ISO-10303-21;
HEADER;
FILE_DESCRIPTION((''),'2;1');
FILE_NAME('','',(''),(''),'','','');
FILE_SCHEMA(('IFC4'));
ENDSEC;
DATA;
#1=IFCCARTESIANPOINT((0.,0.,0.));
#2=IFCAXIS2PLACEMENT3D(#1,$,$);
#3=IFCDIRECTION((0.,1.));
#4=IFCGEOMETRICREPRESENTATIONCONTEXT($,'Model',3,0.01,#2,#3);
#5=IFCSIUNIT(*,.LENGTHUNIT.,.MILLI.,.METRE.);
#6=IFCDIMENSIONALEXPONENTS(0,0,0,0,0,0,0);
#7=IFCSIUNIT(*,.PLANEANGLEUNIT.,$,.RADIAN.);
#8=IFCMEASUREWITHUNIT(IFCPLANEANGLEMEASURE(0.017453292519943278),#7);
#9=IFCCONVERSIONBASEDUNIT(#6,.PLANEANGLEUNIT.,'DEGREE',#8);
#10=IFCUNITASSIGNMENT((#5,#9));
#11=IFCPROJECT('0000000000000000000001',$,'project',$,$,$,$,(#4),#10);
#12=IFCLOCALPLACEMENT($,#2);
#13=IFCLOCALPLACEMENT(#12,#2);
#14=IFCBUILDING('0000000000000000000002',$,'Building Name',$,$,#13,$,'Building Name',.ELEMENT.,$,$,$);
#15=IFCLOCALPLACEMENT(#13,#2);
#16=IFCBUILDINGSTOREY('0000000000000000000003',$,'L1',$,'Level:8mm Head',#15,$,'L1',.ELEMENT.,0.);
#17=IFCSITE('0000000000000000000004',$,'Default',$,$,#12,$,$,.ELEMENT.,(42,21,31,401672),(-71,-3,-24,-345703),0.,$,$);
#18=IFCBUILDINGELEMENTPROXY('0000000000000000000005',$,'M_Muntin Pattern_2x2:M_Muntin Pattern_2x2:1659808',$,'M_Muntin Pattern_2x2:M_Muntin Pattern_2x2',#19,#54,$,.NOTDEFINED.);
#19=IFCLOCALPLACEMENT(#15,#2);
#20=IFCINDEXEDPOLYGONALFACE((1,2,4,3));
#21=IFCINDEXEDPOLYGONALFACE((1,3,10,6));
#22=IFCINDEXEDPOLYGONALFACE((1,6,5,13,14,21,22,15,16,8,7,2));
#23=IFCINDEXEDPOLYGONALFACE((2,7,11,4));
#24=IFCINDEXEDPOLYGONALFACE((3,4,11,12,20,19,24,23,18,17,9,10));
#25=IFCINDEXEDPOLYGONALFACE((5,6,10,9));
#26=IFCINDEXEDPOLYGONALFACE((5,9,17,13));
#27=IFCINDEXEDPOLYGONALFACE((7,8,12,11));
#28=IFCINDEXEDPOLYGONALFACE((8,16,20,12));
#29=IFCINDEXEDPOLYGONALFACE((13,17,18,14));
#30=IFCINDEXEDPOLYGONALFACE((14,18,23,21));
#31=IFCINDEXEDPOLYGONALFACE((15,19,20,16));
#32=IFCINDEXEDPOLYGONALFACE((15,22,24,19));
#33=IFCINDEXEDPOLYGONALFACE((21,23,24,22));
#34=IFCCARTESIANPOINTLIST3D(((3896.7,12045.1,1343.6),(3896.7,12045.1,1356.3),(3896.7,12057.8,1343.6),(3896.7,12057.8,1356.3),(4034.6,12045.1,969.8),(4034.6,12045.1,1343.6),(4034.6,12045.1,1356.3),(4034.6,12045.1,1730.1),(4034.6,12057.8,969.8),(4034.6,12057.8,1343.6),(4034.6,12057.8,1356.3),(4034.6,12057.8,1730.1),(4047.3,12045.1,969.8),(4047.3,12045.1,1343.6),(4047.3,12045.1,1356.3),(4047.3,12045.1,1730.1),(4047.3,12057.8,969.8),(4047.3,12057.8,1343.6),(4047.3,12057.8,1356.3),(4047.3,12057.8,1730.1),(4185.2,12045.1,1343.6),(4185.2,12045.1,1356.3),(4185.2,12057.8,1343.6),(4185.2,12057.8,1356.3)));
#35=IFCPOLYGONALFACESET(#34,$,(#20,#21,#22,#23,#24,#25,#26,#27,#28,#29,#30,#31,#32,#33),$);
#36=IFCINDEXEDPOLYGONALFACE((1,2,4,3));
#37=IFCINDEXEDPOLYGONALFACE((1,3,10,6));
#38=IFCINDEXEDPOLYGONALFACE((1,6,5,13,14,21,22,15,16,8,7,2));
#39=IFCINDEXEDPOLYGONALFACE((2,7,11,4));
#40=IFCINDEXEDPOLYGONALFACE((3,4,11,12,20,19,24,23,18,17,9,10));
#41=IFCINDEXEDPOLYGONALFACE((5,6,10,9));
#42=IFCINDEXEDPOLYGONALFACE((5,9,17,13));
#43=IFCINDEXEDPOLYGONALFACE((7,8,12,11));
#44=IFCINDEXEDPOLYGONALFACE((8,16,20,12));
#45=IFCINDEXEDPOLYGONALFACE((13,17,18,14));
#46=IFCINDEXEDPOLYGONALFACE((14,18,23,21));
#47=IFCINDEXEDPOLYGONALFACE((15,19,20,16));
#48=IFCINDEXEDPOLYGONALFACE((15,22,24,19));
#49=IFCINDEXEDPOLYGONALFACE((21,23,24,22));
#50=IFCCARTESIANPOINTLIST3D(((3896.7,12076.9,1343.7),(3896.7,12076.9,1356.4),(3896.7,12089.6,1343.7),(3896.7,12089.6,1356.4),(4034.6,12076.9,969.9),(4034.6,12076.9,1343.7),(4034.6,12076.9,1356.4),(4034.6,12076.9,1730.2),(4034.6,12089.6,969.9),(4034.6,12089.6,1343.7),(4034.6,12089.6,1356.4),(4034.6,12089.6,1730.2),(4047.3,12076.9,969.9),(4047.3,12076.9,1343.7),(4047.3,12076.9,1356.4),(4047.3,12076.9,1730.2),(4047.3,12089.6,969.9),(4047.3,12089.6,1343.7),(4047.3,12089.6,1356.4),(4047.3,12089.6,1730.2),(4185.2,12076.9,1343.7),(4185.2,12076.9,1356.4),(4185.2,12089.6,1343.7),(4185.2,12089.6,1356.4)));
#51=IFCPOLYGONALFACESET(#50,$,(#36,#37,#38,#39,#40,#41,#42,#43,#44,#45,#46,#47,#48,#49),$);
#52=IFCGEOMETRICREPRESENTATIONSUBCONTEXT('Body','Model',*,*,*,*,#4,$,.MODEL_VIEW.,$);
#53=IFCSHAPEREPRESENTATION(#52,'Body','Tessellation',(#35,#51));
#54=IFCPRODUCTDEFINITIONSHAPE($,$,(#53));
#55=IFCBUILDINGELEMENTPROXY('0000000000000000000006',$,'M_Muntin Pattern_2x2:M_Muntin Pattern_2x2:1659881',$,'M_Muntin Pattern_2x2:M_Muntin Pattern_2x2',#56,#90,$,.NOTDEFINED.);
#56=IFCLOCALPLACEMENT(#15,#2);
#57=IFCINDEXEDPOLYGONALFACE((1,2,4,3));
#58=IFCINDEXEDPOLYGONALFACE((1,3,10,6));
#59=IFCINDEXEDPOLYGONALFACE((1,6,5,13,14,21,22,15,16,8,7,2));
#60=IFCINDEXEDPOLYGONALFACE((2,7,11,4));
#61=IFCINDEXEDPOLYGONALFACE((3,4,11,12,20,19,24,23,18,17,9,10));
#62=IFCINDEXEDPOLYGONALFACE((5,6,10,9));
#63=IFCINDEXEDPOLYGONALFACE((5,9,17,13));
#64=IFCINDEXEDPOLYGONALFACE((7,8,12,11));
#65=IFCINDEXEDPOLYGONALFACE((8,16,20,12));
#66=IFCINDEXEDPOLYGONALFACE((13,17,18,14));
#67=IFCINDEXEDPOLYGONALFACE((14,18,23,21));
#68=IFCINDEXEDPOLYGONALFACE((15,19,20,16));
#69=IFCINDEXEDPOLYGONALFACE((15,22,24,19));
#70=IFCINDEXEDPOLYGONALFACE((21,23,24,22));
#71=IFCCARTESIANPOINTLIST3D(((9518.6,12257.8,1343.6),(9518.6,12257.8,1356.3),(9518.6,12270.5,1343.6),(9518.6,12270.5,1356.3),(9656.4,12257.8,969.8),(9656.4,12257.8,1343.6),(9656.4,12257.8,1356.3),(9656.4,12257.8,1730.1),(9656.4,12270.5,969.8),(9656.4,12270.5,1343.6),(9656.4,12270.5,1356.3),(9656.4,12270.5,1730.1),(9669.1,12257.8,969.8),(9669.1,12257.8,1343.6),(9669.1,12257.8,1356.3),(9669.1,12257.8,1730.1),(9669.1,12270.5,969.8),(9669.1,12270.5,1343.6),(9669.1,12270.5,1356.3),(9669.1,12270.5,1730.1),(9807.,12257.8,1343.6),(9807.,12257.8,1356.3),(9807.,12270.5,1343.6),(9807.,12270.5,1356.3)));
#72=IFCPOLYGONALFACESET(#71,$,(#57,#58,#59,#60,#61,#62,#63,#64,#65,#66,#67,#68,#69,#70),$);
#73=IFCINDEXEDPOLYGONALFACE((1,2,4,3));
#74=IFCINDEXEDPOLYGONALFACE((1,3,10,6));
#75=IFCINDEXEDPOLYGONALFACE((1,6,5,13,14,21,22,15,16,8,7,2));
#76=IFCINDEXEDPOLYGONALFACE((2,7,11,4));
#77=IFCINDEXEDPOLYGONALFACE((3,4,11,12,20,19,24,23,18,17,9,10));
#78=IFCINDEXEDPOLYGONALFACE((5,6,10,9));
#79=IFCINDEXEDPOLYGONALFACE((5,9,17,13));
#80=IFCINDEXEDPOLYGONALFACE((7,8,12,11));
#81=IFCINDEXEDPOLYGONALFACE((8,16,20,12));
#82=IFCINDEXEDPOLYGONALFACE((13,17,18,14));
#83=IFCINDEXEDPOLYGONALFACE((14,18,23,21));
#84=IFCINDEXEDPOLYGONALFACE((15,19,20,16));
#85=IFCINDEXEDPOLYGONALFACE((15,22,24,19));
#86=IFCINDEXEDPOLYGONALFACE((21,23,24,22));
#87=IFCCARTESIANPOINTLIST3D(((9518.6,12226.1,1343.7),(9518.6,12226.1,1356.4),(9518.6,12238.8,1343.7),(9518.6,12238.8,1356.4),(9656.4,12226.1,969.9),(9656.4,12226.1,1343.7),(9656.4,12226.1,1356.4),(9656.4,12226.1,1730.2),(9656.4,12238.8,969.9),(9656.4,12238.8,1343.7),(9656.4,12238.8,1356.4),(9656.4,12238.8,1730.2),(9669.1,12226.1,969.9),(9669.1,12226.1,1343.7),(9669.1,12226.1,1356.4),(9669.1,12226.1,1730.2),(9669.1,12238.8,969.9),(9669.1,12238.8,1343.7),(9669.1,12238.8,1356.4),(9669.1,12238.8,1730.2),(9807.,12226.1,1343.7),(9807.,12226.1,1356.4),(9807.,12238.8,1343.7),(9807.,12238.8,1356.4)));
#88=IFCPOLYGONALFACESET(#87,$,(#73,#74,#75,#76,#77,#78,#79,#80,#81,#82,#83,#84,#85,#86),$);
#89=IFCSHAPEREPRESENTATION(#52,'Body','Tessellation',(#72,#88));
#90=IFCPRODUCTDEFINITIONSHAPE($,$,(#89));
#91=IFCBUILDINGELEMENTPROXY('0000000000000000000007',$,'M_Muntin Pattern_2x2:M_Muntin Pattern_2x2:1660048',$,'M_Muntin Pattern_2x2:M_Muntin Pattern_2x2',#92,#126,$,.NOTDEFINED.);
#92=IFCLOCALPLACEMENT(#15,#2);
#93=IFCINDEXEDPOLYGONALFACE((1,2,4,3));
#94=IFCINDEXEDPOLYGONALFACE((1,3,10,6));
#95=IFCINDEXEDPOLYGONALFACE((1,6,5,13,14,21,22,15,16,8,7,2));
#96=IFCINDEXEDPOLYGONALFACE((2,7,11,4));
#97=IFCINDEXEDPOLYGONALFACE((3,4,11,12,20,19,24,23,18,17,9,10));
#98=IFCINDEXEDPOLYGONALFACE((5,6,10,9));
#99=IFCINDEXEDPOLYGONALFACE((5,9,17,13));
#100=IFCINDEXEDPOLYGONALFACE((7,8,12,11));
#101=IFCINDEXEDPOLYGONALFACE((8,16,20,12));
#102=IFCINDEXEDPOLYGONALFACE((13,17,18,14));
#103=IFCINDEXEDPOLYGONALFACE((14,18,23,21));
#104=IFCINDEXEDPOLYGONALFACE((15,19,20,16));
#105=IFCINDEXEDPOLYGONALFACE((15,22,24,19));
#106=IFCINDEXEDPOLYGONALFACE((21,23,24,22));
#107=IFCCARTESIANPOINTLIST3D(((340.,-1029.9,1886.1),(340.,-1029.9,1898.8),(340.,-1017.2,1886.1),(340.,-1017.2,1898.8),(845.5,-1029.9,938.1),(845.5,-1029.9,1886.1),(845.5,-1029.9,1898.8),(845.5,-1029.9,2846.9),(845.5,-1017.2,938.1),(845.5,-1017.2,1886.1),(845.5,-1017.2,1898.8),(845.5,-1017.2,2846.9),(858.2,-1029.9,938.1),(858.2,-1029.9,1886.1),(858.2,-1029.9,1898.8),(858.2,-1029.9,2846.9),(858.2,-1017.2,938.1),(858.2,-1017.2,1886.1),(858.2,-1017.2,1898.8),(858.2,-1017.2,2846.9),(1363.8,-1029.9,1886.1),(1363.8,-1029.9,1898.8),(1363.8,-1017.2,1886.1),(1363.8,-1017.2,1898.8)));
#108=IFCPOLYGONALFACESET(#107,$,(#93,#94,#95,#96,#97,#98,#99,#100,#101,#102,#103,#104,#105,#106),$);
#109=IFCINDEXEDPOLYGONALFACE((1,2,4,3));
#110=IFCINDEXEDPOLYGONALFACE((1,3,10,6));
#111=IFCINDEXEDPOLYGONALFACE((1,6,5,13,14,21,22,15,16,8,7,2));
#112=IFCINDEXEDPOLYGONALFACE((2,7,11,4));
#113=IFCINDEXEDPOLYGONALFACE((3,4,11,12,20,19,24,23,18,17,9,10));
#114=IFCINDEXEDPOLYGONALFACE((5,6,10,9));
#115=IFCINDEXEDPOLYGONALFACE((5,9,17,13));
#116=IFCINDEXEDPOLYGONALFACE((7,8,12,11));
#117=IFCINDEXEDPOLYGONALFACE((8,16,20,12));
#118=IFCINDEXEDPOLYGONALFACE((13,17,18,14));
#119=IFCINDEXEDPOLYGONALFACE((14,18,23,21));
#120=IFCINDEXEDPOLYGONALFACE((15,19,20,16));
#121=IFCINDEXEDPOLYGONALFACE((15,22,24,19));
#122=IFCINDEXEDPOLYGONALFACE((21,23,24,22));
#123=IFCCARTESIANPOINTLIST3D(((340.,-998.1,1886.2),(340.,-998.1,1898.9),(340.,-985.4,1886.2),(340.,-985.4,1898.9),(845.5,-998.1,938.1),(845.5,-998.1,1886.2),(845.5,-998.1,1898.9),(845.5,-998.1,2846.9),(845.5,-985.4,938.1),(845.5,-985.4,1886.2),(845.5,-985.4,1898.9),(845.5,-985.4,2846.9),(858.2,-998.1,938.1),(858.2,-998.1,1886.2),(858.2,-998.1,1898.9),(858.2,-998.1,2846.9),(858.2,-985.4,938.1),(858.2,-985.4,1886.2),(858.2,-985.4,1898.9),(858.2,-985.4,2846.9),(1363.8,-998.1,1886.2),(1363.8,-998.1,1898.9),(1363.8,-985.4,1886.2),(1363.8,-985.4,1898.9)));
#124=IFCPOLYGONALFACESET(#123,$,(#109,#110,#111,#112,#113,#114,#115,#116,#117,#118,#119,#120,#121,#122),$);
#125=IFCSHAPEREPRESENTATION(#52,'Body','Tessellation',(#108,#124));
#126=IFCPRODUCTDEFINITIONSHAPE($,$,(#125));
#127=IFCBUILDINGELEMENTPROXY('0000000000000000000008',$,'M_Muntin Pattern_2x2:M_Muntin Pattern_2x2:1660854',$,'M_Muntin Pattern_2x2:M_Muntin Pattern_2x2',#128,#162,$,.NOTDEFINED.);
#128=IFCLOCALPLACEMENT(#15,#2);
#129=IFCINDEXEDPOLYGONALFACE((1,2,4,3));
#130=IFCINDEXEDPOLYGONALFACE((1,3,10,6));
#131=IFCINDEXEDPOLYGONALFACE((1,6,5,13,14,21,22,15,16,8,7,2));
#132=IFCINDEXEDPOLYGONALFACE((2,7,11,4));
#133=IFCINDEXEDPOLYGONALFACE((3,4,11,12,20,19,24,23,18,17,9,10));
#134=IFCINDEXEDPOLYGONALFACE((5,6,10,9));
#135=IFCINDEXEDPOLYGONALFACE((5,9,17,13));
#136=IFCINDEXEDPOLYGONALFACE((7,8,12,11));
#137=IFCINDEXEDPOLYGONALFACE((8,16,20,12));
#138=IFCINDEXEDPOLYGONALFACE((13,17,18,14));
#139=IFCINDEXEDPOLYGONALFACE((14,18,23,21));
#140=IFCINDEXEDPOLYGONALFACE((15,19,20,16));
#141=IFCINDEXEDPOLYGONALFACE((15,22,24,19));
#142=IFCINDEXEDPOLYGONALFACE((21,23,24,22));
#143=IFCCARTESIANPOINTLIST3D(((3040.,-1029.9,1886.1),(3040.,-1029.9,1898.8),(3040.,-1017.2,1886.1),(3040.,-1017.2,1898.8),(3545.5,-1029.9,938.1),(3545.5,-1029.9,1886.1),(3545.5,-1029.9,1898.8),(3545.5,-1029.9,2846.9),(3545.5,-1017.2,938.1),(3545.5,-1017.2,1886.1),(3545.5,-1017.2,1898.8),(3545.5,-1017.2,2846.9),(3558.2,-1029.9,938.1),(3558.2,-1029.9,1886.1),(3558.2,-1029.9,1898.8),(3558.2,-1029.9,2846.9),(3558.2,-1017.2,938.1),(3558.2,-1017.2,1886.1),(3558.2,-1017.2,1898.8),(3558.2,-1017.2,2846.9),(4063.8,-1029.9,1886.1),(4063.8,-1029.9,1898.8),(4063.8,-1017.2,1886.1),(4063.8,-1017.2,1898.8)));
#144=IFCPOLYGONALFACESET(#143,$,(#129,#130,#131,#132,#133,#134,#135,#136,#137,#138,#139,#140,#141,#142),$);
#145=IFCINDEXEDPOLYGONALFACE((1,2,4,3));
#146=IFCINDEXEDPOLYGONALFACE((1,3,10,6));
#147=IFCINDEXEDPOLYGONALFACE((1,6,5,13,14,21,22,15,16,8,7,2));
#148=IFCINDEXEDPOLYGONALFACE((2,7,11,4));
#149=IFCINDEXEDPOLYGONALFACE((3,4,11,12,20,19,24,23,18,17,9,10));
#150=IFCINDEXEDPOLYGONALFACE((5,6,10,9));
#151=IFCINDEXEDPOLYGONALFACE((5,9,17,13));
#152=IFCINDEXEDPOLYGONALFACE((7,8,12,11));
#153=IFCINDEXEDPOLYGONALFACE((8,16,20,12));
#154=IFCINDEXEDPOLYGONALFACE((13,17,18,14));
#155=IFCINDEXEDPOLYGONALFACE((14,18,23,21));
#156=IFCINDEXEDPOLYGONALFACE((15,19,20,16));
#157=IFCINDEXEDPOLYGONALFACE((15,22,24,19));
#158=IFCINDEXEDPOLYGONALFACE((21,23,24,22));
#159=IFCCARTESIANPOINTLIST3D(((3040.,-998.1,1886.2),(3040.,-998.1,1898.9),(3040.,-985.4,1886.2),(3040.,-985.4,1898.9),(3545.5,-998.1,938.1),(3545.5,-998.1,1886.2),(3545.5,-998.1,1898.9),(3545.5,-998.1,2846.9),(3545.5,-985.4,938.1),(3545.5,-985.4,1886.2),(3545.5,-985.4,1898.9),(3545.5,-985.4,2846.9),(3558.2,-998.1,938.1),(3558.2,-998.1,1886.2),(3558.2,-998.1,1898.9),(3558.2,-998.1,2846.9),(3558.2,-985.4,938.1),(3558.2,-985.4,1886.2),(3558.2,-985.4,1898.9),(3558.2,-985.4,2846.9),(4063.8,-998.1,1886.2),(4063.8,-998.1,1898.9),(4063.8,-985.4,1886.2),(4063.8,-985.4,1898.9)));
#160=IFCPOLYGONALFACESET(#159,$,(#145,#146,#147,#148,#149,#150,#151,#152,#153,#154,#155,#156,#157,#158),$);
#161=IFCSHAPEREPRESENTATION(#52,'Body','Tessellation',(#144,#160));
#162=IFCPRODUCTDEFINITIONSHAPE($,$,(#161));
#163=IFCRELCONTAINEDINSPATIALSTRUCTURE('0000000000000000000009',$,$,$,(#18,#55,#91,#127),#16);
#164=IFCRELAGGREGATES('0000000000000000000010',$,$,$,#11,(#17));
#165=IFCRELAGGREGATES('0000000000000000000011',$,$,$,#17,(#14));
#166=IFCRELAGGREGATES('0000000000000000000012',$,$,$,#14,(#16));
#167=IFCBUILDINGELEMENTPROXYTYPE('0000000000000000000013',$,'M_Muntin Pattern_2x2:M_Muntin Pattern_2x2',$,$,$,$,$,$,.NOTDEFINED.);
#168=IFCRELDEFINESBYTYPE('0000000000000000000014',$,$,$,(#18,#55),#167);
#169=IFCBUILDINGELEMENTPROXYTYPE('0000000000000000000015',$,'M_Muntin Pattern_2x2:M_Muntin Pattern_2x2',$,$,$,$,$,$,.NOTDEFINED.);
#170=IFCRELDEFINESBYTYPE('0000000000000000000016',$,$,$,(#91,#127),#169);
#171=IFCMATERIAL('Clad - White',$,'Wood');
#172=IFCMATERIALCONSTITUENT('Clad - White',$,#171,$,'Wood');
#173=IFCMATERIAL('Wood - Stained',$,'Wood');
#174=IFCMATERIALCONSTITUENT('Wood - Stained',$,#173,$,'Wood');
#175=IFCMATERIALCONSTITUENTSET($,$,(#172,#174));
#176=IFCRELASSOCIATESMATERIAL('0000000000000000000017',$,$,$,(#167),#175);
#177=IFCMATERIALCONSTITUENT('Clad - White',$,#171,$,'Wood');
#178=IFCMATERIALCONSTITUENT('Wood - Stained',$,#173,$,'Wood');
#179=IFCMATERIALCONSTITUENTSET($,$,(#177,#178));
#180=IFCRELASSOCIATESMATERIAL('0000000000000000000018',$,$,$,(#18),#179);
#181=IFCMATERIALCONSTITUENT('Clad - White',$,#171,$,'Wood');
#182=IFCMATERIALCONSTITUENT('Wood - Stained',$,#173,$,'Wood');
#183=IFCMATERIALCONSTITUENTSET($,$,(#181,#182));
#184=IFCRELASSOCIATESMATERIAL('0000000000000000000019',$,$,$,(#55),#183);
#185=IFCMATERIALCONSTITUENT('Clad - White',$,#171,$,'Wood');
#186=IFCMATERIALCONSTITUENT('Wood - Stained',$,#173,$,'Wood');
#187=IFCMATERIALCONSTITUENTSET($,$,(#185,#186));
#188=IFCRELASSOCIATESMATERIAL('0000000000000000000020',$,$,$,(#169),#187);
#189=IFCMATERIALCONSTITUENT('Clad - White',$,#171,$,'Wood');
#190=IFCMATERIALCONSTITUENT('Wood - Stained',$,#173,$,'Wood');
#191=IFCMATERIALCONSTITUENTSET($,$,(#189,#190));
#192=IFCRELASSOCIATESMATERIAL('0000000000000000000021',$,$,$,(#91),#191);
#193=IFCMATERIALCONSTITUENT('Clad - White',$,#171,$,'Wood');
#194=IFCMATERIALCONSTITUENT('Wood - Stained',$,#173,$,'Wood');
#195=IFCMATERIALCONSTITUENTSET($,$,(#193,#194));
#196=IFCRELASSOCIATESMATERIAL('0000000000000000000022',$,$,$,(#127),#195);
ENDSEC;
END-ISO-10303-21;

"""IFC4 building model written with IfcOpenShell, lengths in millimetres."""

from ifc_helpers import new_model, entity, si_unit, converted_unit, direction, frame, origin, place, context, subcontext, project, spatial, indexed_curve, outline, extrude, source, transform, mapped, material, constituent, constituent_set, type_object, type_shapes, element, save


model = new_model("IFC4")

# Units and contexts
model_context = context("Model", 3, precision=0.01, world=origin(), true_north=direction((0.0, 1.0)))
body_context = subcontext(model_context, "Body", "Model", "MODEL_VIEW")
ifc_project = project(units=[si_unit("LENGTHUNIT", "METRE", prefix="MILLI"), converted_unit("PLANEANGLEUNIT", "DEGREE", entity("IfcPlaneAngleMeasure", 0.017453292519943278), si_unit("PLANEANGLEUNIT", "RADIAN"), dimensions=[0, 0, 0, 0, 0, 0, 0])], contexts=[model_context])

# Site, building, storey
site_placement = place(None, origin())
site = spatial("IfcSite", under=ifc_project, at=site_placement, Name="Default", CompositionType="ELEMENT", RefLatitude=(42, 21, 31, 401672), RefLongitude=(-71, -3, -24, -345703), RefElevation=0.0)
building_placement = place(site_placement, origin())
building = spatial("IfcBuilding", under=site, at=building_placement, Name="Building Name", LongName="Building Name", CompositionType="ELEMENT")
storey_placement = place(building_placement, origin())
storey = spatial("IfcBuildingStorey", under=building, at=storey_placement, Name="L1", ObjectType="Level:8mm Head", LongName="L1", CompositionType="ELEMENT", Elevation=0.0)

# Building element proxies
ifc_material_1 = material(Name="Clad - White", Category="Wood")
ifc_material_2 = material(Name="Wood - Stained", Category="Wood")
ifc_constituent_1 = constituent(ifc_material_1, Name="Clad - White", Category="Wood")
ifc_constituent_2 = constituent(ifc_material_2, Name="Wood - Stained", Category="Wood")
ifc_constituent_set_1 = constituent_set(constituents=[ifc_constituent_1, ifc_constituent_2])
ifc_constituent_3 = constituent(ifc_material_1, Name="Clad - White", Category="Wood")
ifc_constituent_4 = constituent(ifc_material_2, Name="Wood - Stained", Category="Wood")
ifc_constituent_set_2 = constituent_set(constituents=[ifc_constituent_3, ifc_constituent_4])
building_element_proxy_type_1 = type_object("IfcBuildingElementProxyType", Name="M_Muntin Pattern_2x2:M_Muntin Pattern_2x2", PredefinedType="NOTDEFINED", material=ifc_constituent_set_2)
shared_shape_1 = source(origin(), body_context, "Body", "SweptSolid", [
    extrude(outline(indexed_curve([(6.4, -6.4), (380.1, -6.4), (380.1, 6.3), (6.4, 6.3), (6.4, 144.2), (-6.3, 144.2), (-6.3, 6.3), (-380.2, 6.3), (-380.2, -6.4), (-6.3, -6.4), (-6.3, -144.2), (6.4, -144.2), (6.4, -6.4)], self_intersect=False)), frame((0.0, -22.2, 380.1), z_axis=(0.0, 1.0, 0.0), x_axis=(0.0, 0.0, 1.0)), (0.0, 0.0, 1.0), 12.7),
    extrude(outline(indexed_curve([(6.4, -6.4), (380.2, -6.4), (380.2, 6.3), (6.4, 6.3), (6.4, 144.2), (-6.3, 144.2), (-6.3, 6.3), (-380.2, 6.3), (-380.2, -6.4), (-6.3, -6.4), (-6.3, -144.2), (6.4, -144.2), (6.4, -6.4)], self_intersect=False)), frame((0.0, 9.5, 380.2), z_axis=(0.0, 1.0, 0.0), x_axis=(0.0, 0.0, 1.0)), (0.0, 0.0, 1.0), 12.7),
])
type_shapes(building_element_proxy_type_1, [shared_shape_1])
proxy_1_placement = place(storey_placement, frame((4041.0, 12067.3, 969.9)))
element("IfcBuildingElementProxy", 1, at=proxy_1_placement, inside=storey, type_object=building_element_proxy_type_1, material=ifc_constituent_set_1, Name="M_Muntin Pattern_2x2:M_Muntin Pattern_2x2:1659808", ObjectType="M_Muntin Pattern_2x2:M_Muntin Pattern_2x2", PredefinedType="NOTDEFINED", context=body_context, shape_type="MappedRepresentation", body=[
    mapped(shared_shape_1, transform((0.0, 0.0, 0.0), scale=1.0)),
])
ifc_constituent_5 = constituent(ifc_material_1, Name="Clad - White", Category="Wood")
ifc_constituent_6 = constituent(ifc_material_2, Name="Wood - Stained", Category="Wood")
ifc_constituent_set_3 = constituent_set(constituents=[ifc_constituent_5, ifc_constituent_6])
proxy_2_placement = place(storey_placement, frame((9662.8, 12248.3, 969.9), z_axis=(0.0, 0.0, 1.0), x_axis=(-1.0, 0.0, 0.0)))
element("IfcBuildingElementProxy", 2, at=proxy_2_placement, inside=storey, type_object=building_element_proxy_type_1, material=ifc_constituent_set_3, Name="M_Muntin Pattern_2x2:M_Muntin Pattern_2x2:1659881", ObjectType="M_Muntin Pattern_2x2:M_Muntin Pattern_2x2", PredefinedType="NOTDEFINED", context=body_context, shape_type="MappedRepresentation", body=[
    mapped(shared_shape_1, transform((0.0, 0.0, 0.0), scale=1.0)),
])
ifc_constituent_7 = constituent(ifc_material_1, Name="Clad - White", Category="Wood")
ifc_constituent_8 = constituent(ifc_material_2, Name="Wood - Stained", Category="Wood")
ifc_constituent_set_4 = constituent_set(constituents=[ifc_constituent_7, ifc_constituent_8])
ifc_constituent_9 = constituent(ifc_material_1, Name="Clad - White", Category="Wood")
ifc_constituent_10 = constituent(ifc_material_2, Name="Wood - Stained", Category="Wood")
ifc_constituent_set_5 = constituent_set(constituents=[ifc_constituent_9, ifc_constituent_10])
building_element_proxy_type_2 = type_object("IfcBuildingElementProxyType", Name="M_Muntin Pattern_2x2:M_Muntin Pattern_2x2", PredefinedType="NOTDEFINED", material=ifc_constituent_set_5)
shared_shape_2 = source(origin(), body_context, "Body", "SweptSolid", [
    extrude(outline(indexed_curve([(6.4, -6.4), (954.4, -6.4), (954.4, 6.3), (6.4, 6.3), (6.4, 511.9), (-6.3, 511.9), (-6.3, 6.3), (-954.4, 6.3), (-954.4, -6.4), (-6.3, -6.4), (-6.3, -511.9), (6.4, -511.9), (6.4, -6.4)], self_intersect=False)), frame((0.0, -22.2, 954.4), z_axis=(0.0, 1.0, 0.0), x_axis=(0.0, 0.0, 1.0)), (0.0, 0.0, 1.0), 12.7),
    extrude(outline(indexed_curve([(6.4, -6.4), (954.4, -6.4), (954.4, 6.3), (6.4, 6.3), (6.4, 511.9), (-6.3, 511.9), (-6.3, 6.3), (-954.4, 6.3), (-954.4, -6.4), (-6.3, -6.4), (-6.3, -511.9), (6.4, -511.9), (6.4, -6.4)], self_intersect=False)), frame((0.0, 9.5, 954.4), z_axis=(0.0, 1.0, 0.0), x_axis=(0.0, 0.0, 1.0)), (0.0, 0.0, 1.0), 12.7),
])
type_shapes(building_element_proxy_type_2, [shared_shape_2])
proxy_3_placement = place(storey_placement, frame((851.9, -1007.7, 938.1)))
element("IfcBuildingElementProxy", 3, at=proxy_3_placement, inside=storey, type_object=building_element_proxy_type_2, material=ifc_constituent_set_4, Name="M_Muntin Pattern_2x2:M_Muntin Pattern_2x2:1660048", ObjectType="M_Muntin Pattern_2x2:M_Muntin Pattern_2x2", PredefinedType="NOTDEFINED", context=body_context, shape_type="MappedRepresentation", body=[
    mapped(shared_shape_2, transform((0.0, 0.0, 0.0), scale=1.0)),
])
ifc_constituent_11 = constituent(ifc_material_1, Name="Clad - White", Category="Wood")
ifc_constituent_12 = constituent(ifc_material_2, Name="Wood - Stained", Category="Wood")
ifc_constituent_set_6 = constituent_set(constituents=[ifc_constituent_11, ifc_constituent_12])
proxy_4_placement = place(storey_placement, frame((3551.9, -1007.7, 938.1)))
element("IfcBuildingElementProxy", 4, at=proxy_4_placement, inside=storey, type_object=building_element_proxy_type_2, material=ifc_constituent_set_6, Name="M_Muntin Pattern_2x2:M_Muntin Pattern_2x2:1660854", ObjectType="M_Muntin Pattern_2x2:M_Muntin Pattern_2x2", PredefinedType="NOTDEFINED", context=body_context, shape_type="MappedRepresentation", body=[
    mapped(shared_shape_2, transform((0.0, 0.0, 0.0), scale=1.0)),
])

save(model, "model.ifc")
